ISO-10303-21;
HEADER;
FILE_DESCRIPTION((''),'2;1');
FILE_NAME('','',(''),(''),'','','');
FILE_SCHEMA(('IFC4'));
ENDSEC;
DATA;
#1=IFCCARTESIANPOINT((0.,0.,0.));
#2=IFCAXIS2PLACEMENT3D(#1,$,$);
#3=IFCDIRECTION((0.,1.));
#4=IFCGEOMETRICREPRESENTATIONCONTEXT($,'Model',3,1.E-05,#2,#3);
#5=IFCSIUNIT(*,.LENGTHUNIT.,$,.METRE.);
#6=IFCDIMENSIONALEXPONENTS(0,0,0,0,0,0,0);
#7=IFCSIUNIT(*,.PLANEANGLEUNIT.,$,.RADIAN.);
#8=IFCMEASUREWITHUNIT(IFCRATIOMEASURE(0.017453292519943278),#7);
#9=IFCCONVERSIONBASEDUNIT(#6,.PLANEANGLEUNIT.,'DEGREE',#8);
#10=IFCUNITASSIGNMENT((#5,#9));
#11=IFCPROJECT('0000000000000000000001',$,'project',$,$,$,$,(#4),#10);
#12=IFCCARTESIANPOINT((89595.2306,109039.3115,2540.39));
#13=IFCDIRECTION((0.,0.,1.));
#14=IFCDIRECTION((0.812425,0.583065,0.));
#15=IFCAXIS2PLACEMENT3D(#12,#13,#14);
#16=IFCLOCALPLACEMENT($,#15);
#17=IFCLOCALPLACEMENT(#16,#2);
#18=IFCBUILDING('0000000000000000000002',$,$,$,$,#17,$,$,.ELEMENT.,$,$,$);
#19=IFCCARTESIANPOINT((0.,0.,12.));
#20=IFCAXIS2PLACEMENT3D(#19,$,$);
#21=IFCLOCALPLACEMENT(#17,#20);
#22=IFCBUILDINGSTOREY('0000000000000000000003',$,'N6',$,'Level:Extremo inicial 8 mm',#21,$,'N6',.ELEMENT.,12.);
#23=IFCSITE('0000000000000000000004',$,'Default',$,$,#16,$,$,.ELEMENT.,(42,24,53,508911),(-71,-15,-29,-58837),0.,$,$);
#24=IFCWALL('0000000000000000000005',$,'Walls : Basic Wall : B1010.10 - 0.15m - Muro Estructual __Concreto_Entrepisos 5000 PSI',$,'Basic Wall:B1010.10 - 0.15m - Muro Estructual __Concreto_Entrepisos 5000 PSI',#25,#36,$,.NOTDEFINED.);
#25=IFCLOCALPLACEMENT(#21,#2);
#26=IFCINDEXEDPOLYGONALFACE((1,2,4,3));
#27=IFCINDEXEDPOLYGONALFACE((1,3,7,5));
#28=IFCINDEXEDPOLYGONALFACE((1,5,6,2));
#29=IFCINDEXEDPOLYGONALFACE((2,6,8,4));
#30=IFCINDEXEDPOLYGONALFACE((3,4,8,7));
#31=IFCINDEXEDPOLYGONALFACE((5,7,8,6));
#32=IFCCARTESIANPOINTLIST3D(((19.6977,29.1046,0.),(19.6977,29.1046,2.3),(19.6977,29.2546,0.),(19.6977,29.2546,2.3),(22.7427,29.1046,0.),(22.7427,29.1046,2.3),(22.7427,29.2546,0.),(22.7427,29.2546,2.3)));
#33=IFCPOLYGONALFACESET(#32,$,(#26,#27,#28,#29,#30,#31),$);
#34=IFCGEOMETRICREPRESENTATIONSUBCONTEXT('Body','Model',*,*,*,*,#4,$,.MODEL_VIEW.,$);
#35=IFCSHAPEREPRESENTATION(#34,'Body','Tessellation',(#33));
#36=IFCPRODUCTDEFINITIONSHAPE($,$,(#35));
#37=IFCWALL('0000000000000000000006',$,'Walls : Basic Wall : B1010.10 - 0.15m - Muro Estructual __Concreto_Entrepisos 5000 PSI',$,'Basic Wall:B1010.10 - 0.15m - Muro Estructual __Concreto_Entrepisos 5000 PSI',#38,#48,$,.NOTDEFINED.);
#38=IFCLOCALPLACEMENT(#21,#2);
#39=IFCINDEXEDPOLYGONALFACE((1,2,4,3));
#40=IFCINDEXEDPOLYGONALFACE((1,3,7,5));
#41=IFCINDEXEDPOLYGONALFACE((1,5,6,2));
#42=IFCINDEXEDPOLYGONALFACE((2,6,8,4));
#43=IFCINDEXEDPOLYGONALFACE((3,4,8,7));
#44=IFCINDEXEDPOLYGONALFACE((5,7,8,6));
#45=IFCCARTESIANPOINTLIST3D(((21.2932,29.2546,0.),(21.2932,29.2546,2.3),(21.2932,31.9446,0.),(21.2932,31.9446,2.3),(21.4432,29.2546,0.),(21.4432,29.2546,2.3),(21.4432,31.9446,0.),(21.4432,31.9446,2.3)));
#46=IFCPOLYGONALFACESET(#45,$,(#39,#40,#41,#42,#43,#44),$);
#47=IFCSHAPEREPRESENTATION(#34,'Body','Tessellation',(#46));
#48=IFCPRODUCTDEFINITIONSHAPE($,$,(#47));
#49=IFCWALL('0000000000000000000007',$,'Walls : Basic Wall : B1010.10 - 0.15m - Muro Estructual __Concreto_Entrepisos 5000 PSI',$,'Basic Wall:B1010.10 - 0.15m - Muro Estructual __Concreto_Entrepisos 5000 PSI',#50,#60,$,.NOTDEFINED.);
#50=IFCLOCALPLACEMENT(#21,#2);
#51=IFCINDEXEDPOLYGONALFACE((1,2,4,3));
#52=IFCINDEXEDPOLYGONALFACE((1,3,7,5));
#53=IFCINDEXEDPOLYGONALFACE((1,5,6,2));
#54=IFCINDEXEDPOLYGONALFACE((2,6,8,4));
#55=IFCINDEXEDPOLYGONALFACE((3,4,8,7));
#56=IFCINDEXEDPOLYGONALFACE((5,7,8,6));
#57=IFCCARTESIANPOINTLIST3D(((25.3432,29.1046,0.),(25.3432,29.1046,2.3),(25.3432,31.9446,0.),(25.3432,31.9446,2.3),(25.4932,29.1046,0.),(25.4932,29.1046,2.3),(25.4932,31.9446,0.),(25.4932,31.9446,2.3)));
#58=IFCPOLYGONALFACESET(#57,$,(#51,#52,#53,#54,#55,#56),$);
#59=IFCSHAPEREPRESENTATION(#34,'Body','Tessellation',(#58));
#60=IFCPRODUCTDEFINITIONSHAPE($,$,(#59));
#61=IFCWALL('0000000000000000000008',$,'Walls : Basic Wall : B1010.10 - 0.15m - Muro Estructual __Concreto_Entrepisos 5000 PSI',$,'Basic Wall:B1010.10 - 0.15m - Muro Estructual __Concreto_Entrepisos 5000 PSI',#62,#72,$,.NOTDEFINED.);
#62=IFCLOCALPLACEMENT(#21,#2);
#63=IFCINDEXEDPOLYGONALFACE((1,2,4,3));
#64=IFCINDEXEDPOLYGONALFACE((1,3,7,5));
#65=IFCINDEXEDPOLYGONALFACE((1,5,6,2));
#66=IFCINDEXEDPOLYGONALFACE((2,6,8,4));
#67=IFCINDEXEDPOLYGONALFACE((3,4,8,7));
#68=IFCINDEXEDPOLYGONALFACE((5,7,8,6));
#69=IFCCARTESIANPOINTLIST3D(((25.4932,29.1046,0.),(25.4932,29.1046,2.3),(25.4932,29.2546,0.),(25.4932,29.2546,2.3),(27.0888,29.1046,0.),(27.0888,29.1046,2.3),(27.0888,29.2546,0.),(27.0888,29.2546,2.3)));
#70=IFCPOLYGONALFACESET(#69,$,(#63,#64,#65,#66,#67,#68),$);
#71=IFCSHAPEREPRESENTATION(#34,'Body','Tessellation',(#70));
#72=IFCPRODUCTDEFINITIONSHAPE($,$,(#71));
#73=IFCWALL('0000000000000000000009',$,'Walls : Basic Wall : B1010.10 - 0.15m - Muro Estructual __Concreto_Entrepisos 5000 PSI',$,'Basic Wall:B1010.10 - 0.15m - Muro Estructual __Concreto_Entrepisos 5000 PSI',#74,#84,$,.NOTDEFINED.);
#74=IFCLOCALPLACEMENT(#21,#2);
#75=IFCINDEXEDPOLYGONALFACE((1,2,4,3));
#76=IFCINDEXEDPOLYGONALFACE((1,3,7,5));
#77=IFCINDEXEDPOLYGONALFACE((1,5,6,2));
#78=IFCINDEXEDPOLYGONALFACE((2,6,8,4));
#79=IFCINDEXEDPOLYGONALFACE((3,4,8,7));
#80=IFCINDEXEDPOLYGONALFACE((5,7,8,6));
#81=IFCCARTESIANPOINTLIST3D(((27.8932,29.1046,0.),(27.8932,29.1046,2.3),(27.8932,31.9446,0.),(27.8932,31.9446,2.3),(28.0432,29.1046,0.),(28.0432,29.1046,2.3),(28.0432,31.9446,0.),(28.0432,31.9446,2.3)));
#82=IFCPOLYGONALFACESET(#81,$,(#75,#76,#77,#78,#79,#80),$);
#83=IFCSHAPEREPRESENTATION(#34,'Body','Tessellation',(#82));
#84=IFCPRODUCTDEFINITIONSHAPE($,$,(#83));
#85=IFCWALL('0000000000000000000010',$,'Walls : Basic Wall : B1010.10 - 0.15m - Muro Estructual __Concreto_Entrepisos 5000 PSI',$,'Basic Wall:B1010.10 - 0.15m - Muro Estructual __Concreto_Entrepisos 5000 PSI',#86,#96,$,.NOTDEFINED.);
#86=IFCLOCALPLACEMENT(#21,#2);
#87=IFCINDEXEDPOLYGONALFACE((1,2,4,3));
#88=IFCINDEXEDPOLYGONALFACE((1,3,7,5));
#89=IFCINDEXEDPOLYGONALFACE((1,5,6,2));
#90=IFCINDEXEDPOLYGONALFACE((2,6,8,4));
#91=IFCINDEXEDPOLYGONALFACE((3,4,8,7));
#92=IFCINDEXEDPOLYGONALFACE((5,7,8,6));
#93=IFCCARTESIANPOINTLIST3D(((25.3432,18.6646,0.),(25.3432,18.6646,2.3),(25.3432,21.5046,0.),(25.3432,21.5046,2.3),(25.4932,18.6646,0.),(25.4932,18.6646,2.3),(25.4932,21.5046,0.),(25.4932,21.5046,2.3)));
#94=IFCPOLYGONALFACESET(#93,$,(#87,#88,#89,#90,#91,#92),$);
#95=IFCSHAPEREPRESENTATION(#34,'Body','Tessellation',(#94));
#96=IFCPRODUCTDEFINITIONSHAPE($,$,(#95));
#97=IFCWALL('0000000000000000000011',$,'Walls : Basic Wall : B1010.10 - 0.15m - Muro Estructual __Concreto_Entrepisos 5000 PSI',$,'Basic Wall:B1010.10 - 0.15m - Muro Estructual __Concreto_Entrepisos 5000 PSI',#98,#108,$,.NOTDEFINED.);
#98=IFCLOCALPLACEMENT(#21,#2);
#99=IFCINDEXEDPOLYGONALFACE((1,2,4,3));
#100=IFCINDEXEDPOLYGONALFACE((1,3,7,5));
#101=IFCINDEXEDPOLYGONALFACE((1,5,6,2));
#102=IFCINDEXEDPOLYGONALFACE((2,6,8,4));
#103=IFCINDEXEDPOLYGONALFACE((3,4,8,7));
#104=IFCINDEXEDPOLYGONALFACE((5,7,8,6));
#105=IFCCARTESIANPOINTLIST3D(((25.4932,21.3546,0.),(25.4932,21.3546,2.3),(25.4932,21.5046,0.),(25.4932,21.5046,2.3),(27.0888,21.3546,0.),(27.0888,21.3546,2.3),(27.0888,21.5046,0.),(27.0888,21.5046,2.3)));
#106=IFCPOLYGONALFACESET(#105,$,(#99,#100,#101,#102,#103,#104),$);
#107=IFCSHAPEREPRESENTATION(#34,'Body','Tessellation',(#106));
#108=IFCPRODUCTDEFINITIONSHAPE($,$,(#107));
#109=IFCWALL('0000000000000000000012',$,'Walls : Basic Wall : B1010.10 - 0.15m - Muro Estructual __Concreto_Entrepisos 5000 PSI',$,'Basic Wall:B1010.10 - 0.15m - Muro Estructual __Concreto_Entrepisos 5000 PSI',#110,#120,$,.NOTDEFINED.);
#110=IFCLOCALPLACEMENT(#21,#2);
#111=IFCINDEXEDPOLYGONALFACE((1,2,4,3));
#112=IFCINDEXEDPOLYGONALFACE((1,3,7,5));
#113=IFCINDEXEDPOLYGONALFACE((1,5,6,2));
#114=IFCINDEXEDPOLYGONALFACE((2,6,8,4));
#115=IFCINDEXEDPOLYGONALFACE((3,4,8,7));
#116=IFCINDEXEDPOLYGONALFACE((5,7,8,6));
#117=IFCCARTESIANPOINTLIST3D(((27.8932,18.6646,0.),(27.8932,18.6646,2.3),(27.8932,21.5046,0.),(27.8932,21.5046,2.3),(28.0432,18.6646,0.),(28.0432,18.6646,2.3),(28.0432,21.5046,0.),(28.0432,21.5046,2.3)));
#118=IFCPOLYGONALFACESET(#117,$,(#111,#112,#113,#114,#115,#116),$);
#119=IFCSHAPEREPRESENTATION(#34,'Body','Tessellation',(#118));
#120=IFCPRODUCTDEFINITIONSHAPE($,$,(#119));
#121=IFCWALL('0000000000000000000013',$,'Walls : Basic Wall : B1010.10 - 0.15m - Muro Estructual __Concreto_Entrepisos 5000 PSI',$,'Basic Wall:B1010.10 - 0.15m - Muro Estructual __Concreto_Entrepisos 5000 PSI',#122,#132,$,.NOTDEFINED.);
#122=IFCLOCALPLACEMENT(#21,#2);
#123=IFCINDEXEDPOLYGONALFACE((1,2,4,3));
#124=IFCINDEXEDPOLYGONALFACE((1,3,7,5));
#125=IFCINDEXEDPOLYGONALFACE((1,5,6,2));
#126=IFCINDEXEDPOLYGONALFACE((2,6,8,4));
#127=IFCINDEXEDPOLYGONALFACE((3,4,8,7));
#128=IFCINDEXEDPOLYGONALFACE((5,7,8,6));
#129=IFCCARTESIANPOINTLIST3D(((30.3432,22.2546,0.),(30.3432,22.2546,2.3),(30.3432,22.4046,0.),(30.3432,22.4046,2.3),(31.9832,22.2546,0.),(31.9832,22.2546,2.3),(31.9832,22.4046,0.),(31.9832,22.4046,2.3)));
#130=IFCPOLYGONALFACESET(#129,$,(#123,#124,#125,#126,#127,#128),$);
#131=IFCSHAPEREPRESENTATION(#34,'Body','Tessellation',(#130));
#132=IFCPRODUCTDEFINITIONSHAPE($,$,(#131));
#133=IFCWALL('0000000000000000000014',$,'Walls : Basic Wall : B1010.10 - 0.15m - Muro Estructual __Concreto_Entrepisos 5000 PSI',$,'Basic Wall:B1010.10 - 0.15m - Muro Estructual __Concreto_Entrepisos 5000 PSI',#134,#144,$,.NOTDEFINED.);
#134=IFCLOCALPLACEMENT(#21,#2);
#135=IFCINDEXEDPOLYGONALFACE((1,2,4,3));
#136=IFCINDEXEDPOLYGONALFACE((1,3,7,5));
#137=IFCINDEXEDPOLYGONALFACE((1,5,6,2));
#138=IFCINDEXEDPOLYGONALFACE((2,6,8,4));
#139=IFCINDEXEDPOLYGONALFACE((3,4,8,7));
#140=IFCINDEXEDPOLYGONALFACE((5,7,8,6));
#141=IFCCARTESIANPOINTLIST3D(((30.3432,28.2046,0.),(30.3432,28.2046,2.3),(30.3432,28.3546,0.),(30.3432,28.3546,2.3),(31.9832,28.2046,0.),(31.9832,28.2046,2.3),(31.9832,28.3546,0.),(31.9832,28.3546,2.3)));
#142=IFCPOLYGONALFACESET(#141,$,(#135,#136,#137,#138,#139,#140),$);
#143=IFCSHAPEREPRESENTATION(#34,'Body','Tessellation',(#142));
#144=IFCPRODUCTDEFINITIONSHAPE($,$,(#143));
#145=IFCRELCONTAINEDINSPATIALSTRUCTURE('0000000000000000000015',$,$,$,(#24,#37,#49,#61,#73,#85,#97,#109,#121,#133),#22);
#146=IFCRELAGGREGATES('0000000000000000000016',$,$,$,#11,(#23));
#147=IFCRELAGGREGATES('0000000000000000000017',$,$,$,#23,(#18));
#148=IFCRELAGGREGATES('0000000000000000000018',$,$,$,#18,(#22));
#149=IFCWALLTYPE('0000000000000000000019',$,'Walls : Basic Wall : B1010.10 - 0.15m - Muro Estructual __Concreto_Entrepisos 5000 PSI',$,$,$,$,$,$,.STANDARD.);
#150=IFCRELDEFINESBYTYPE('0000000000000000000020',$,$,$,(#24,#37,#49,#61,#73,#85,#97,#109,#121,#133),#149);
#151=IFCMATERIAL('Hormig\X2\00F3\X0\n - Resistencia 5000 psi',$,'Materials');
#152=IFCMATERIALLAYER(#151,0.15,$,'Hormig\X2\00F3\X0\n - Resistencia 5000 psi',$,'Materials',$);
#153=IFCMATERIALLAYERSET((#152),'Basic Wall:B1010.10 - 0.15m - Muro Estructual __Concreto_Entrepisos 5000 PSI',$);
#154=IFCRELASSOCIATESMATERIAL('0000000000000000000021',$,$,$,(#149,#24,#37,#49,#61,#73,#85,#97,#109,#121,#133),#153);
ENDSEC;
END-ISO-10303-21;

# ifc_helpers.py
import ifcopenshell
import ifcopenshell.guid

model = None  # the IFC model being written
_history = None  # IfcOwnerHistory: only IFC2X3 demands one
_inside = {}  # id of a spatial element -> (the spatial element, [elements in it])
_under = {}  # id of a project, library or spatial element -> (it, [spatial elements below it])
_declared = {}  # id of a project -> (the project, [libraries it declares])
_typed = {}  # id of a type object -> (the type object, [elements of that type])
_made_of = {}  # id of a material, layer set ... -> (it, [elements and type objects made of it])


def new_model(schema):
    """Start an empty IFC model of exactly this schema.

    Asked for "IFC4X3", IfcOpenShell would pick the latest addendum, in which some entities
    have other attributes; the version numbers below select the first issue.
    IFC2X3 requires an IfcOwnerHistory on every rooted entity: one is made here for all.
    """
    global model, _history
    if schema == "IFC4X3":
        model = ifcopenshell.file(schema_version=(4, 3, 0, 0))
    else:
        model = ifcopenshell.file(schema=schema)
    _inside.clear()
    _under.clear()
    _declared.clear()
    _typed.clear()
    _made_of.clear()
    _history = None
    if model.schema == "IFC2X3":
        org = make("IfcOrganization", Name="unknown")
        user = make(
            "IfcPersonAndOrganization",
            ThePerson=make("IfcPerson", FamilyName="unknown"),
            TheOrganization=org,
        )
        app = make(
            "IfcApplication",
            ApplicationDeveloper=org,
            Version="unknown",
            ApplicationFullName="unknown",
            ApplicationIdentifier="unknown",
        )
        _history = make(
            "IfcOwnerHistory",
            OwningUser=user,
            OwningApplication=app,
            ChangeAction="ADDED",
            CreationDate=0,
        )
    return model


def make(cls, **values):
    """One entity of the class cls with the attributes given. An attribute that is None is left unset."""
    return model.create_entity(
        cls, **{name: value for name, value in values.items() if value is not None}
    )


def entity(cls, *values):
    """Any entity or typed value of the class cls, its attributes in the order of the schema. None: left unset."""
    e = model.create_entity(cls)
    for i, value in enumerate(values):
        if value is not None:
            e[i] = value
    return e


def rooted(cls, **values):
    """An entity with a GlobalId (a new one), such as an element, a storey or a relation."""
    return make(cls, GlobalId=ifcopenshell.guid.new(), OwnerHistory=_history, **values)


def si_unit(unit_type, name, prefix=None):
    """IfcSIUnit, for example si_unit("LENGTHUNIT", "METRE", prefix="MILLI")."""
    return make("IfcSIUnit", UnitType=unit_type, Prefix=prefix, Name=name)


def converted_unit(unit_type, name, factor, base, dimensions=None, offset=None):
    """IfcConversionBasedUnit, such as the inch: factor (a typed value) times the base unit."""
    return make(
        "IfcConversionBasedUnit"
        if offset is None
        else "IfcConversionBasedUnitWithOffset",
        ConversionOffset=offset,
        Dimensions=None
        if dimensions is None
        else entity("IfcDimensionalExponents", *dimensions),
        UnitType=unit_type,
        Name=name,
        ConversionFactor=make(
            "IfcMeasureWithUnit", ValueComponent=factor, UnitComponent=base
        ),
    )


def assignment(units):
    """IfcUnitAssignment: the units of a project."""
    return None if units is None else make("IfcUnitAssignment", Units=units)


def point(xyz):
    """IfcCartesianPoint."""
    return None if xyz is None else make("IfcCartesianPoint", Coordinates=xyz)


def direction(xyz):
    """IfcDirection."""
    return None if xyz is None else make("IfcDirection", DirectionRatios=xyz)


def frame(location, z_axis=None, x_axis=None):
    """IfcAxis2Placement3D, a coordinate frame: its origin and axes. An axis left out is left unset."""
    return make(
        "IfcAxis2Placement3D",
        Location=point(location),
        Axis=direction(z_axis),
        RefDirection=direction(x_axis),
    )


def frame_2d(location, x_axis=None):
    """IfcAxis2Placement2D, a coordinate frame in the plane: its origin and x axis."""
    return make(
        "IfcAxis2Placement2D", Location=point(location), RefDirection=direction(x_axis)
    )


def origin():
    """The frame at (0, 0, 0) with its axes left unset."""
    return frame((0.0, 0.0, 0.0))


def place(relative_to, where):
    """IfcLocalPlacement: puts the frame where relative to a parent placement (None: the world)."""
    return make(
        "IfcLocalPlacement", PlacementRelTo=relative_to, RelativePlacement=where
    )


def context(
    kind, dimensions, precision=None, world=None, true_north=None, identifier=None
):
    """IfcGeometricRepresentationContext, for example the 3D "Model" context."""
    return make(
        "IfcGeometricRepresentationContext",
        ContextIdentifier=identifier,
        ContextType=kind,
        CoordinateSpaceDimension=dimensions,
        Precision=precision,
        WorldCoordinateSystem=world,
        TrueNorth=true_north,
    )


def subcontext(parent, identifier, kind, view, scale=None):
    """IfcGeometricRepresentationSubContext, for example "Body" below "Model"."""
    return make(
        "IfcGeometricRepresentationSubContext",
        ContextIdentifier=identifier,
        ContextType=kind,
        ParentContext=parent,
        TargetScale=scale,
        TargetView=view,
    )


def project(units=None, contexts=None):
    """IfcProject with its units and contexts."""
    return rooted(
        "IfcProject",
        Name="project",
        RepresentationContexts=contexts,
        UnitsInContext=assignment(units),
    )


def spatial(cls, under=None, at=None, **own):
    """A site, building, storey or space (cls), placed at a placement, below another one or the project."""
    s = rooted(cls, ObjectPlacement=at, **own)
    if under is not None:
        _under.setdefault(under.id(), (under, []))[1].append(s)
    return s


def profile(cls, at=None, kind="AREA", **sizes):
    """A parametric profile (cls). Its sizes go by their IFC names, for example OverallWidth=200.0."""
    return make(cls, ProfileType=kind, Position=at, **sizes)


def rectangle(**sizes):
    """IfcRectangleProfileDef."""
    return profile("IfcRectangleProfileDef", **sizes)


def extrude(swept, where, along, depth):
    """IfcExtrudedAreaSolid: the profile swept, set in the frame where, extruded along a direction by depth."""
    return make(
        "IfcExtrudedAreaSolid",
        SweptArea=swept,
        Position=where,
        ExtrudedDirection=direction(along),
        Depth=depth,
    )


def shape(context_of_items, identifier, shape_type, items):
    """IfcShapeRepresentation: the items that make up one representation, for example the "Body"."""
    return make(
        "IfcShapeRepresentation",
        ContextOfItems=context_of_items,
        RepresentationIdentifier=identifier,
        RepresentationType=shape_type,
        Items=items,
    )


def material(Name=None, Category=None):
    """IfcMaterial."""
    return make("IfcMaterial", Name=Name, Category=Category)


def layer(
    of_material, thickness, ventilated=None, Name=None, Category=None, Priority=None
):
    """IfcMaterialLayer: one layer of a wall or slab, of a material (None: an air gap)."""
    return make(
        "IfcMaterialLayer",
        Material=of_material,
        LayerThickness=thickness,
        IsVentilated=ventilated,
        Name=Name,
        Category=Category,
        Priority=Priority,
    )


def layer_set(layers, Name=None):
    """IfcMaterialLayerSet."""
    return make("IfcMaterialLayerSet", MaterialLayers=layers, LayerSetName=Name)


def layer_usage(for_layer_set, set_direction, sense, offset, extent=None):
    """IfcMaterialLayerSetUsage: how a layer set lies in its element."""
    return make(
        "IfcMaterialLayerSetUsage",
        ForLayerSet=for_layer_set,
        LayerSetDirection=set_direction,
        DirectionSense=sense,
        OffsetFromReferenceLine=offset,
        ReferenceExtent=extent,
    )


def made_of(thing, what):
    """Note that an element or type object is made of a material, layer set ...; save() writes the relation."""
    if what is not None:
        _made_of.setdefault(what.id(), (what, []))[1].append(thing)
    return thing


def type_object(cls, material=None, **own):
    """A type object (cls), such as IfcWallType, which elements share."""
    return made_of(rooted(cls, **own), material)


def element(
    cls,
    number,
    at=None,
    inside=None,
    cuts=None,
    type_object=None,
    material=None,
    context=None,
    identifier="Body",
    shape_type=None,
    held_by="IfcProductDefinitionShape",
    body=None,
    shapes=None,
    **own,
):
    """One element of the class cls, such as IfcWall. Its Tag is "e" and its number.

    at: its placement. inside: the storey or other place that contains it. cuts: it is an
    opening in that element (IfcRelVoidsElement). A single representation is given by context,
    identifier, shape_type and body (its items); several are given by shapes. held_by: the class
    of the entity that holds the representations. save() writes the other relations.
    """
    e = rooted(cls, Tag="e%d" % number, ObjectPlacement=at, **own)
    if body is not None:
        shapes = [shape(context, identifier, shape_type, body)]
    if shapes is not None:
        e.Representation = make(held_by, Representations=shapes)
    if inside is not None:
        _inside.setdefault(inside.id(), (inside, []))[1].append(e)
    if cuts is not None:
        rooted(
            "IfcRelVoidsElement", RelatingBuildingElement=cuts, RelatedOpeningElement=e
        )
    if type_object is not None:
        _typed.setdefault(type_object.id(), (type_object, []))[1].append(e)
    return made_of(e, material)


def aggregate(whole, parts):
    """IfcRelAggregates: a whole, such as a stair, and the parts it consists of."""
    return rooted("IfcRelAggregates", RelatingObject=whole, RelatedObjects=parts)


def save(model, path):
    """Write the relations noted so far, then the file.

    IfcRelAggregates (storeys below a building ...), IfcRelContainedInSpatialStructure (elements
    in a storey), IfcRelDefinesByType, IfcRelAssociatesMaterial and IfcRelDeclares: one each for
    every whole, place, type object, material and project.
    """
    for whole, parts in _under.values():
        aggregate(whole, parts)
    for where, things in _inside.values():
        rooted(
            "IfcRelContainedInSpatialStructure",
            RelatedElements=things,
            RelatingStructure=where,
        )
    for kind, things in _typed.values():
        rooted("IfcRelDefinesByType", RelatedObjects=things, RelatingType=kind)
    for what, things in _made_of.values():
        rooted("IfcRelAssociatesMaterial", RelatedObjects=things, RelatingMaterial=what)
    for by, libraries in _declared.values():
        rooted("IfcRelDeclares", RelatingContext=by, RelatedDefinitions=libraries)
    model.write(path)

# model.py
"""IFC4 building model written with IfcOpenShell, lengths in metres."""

from ifc_helpers import new_model, entity, si_unit, converted_unit, direction, frame, frame_2d, origin, place, context, subcontext, project, spatial, rectangle, extrude, material, layer, layer_set, layer_usage, type_object, element, save


model = new_model("IFC4")

# Units and contexts
model_context = context("Model", 3, precision=1e-05, world=origin(), true_north=direction((0.0, 1.0)))
body_context = subcontext(model_context, "Body", "Model", "MODEL_VIEW")
ifc_project = project(units=[si_unit("LENGTHUNIT", "METRE"), converted_unit("PLANEANGLEUNIT", "DEGREE", entity("IfcRatioMeasure", 0.017453292519943278), si_unit("PLANEANGLEUNIT", "RADIAN"), dimensions=[0, 0, 0, 0, 0, 0, 0])], contexts=[model_context])

# Site, building, storey
site_placement = place(None, frame((89595.2306, 109039.3115, 2540.39), z_axis=(0.0, 0.0, 1.0), x_axis=(0.812425, 0.583065, 0.0)))
site = spatial("IfcSite", under=ifc_project, at=site_placement, Name="Default", CompositionType="ELEMENT", RefLatitude=(42, 24, 53, 508911), RefLongitude=(-71, -15, -29, -58837), RefElevation=0.0)
building_placement = place(site_placement, origin())
building = spatial("IfcBuilding", under=site, at=building_placement, CompositionType="ELEMENT")
storey_placement = place(building_placement, frame((0.0, 0.0, 12.0)))
storey = spatial("IfcBuildingStorey", under=building, at=storey_placement, Name="N6", ObjectType="Level:Extremo inicial 8 mm", LongName="N6", CompositionType="ELEMENT", Elevation=12.0)

# Walls
ifc_material_1 = material(Name="Hormigón - Resistencia 5000 psi", Category="Materials")
ifc_layer_1 = layer(ifc_material_1, 0.15, Name="Hormigón - Resistencia 5000 psi", Category="Materials")
ifc_layer_set_1 = layer_set([ifc_layer_1], Name="Basic Wall:B1010.10 - 0.15m - Muro Estructual __Concreto_Entrepisos 5000 PSI")
wall_type_1 = type_object("IfcWallType", Name="Walls : Basic Wall : B1010.10 - 0.15m - Muro Estructual __Concreto_Entrepisos 5000 PSI", PredefinedType="STANDARD", material=ifc_layer_set_1)
ifc_layer_usage_1 = layer_usage(ifc_layer_set_1, "AXIS2", "NEGATIVE", 0.075)
wall_1_placement = place(storey_placement, frame((19.6977, 29.1796, 0.0)))
element("IfcWall", 1, at=wall_1_placement, inside=storey, type_object=wall_type_1, material=ifc_layer_usage_1, Name="Walls : Basic Wall : B1010.10 - 0.15m - Muro Estructual __Concreto_Entrepisos 5000 PSI", ObjectType="Basic Wall:B1010.10 - 0.15m - Muro Estructual __Concreto_Entrepisos 5000 PSI", PredefinedType="NOTDEFINED", context=body_context, shape_type="SweptSolid", body=[
    extrude(rectangle(XDim=3.045, YDim=0.15, at=frame_2d((1.5225, 0.0), x_axis=(-1.0, 0.0))), origin(), (0.0, 0.0, 1.0), 2.3),
])
ifc_layer_usage_2 = layer_usage(ifc_layer_set_1, "AXIS2", "NEGATIVE", 0.075)
wall_2_placement = place(storey_placement, frame((21.3682, 31.9446, 0.0), z_axis=(0.0, 0.0, 1.0), x_axis=(0.0, -1.0, 0.0)))
element("IfcWall", 2, at=wall_2_placement, inside=storey, type_object=wall_type_1, material=ifc_layer_usage_2, Name="Walls : Basic Wall : B1010.10 - 0.15m - Muro Estructual __Concreto_Entrepisos 5000 PSI", ObjectType="Basic Wall:B1010.10 - 0.15m - Muro Estructual __Concreto_Entrepisos 5000 PSI", PredefinedType="NOTDEFINED", context=body_context, shape_type="SweptSolid", body=[
    extrude(rectangle(XDim=2.69, YDim=0.15, at=frame_2d((1.345, 0.0), x_axis=(-1.0, 0.0))), origin(), (0.0, 0.0, 1.0), 2.3),
])
ifc_layer_usage_3 = layer_usage(ifc_layer_set_1, "AXIS2", "NEGATIVE", 0.075)
wall_3_placement = place(storey_placement, frame((25.4182, 31.9446, 0.0), z_axis=(0.0, 0.0, 1.0), x_axis=(0.0, -1.0, 0.0)))
element("IfcWall", 3, at=wall_3_placement, inside=storey, type_object=wall_type_1, material=ifc_layer_usage_3, Name="Walls : Basic Wall : B1010.10 - 0.15m - Muro Estructual __Concreto_Entrepisos 5000 PSI", ObjectType="Basic Wall:B1010.10 - 0.15m - Muro Estructual __Concreto_Entrepisos 5000 PSI", PredefinedType="NOTDEFINED", context=body_context, shape_type="SweptSolid", body=[
    extrude(rectangle(XDim=2.84, YDim=0.15, at=frame_2d((1.42, 0.0), x_axis=(-1.0, 0.0))), origin(), (0.0, 0.0, 1.0), 2.3),
])
ifc_layer_usage_4 = layer_usage(ifc_layer_set_1, "AXIS2", "NEGATIVE", 0.075)
wall_4_placement = place(storey_placement, frame((27.0888, 29.1796, 0.0), z_axis=(0.0, 0.0, 1.0), x_axis=(-1.0, 0.0, 0.0)))
element("IfcWall", 4, at=wall_4_placement, inside=storey, type_object=wall_type_1, material=ifc_layer_usage_4, Name="Walls : Basic Wall : B1010.10 - 0.15m - Muro Estructual __Concreto_Entrepisos 5000 PSI", ObjectType="Basic Wall:B1010.10 - 0.15m - Muro Estructual __Concreto_Entrepisos 5000 PSI", PredefinedType="NOTDEFINED", context=body_context, shape_type="SweptSolid", body=[
    extrude(rectangle(XDim=1.5955, YDim=0.15, at=frame_2d((0.7978, 0.0), x_axis=(-1.0, 0.0))), origin(), (0.0, 0.0, 1.0), 2.3),
])
ifc_layer_usage_5 = layer_usage(ifc_layer_set_1, "AXIS2", "NEGATIVE", 0.075)
wall_5_placement = place(storey_placement, frame((27.9682, 31.9446, 0.0), z_axis=(0.0, 0.0, 1.0), x_axis=(0.0, -1.0, 0.0)))
element("IfcWall", 5, at=wall_5_placement, inside=storey, type_object=wall_type_1, material=ifc_layer_usage_5, Name="Walls : Basic Wall : B1010.10 - 0.15m - Muro Estructual __Concreto_Entrepisos 5000 PSI", ObjectType="Basic Wall:B1010.10 - 0.15m - Muro Estructual __Concreto_Entrepisos 5000 PSI", PredefinedType="NOTDEFINED", context=body_context, shape_type="SweptSolid", body=[
    extrude(rectangle(XDim=2.84, YDim=0.15, at=frame_2d((1.42, 0.0), x_axis=(-1.0, 0.0))), origin(), (0.0, 0.0, 1.0), 2.3),
])
ifc_layer_usage_6 = layer_usage(ifc_layer_set_1, "AXIS2", "NEGATIVE", 0.075)
wall_6_placement = place(storey_placement, frame((25.4182, 18.6646, 0.0), z_axis=(0.0, 0.0, 1.0), x_axis=(0.0, 1.0, 0.0)))
element("IfcWall", 6, at=wall_6_placement, inside=storey, type_object=wall_type_1, material=ifc_layer_usage_6, Name="Walls : Basic Wall : B1010.10 - 0.15m - Muro Estructual __Concreto_Entrepisos 5000 PSI", ObjectType="Basic Wall:B1010.10 - 0.15m - Muro Estructual __Concreto_Entrepisos 5000 PSI", PredefinedType="NOTDEFINED", context=body_context, shape_type="SweptSolid", body=[
    extrude(rectangle(XDim=2.84, YDim=0.15, at=frame_2d((1.42, 0.0), x_axis=(-1.0, 0.0))), origin(), (0.0, 0.0, 1.0), 2.3),
])
ifc_layer_usage_7 = layer_usage(ifc_layer_set_1, "AXIS2", "NEGATIVE", 0.075)
wall_7_placement = place(storey_placement, frame((27.0888, 21.4296, 0.0), z_axis=(0.0, 0.0, 1.0), x_axis=(-1.0, 0.0, 0.0)))
element("IfcWall", 7, at=wall_7_placement, inside=storey, type_object=wall_type_1, material=ifc_layer_usage_7, Name="Walls : Basic Wall : B1010.10 - 0.15m - Muro Estructual __Concreto_Entrepisos 5000 PSI", ObjectType="Basic Wall:B1010.10 - 0.15m - Muro Estructual __Concreto_Entrepisos 5000 PSI", PredefinedType="NOTDEFINED", context=body_context, shape_type="SweptSolid", body=[
    extrude(rectangle(XDim=1.5955, YDim=0.15, at=frame_2d((0.7978, 0.0), x_axis=(-1.0, 0.0))), origin(), (0.0, 0.0, 1.0), 2.3),
])
ifc_layer_usage_8 = layer_usage(ifc_layer_set_1, "AXIS2", "NEGATIVE", 0.075)
wall_8_placement = place(storey_placement, frame((27.9682, 18.6646, 0.0), z_axis=(0.0, 0.0, 1.0), x_axis=(0.0, 1.0, 0.0)))
element("IfcWall", 8, at=wall_8_placement, inside=storey, type_object=wall_type_1, material=ifc_layer_usage_8, Name="Walls : Basic Wall : B1010.10 - 0.15m - Muro Estructual __Concreto_Entrepisos 5000 PSI", ObjectType="Basic Wall:B1010.10 - 0.15m - Muro Estructual __Concreto_Entrepisos 5000 PSI", PredefinedType="NOTDEFINED", context=body_context, shape_type="SweptSolid", body=[
    extrude(rectangle(XDim=2.84, YDim=0.15, at=frame_2d((1.42, 0.0), x_axis=(-1.0, 0.0))), origin(), (0.0, 0.0, 1.0), 2.3),
])
ifc_layer_usage_9 = layer_usage(ifc_layer_set_1, "AXIS2", "NEGATIVE", 0.075)
wall_9_placement = place(storey_placement, frame((31.9832, 22.3296, 0.0), z_axis=(0.0, 0.0, 1.0), x_axis=(-1.0, 0.0, 0.0)))
element("IfcWall", 9, at=wall_9_placement, inside=storey, type_object=wall_type_1, material=ifc_layer_usage_9, Name="Walls : Basic Wall : B1010.10 - 0.15m - Muro Estructual __Concreto_Entrepisos 5000 PSI", ObjectType="Basic Wall:B1010.10 - 0.15m - Muro Estructual __Concreto_Entrepisos 5000 PSI", PredefinedType="NOTDEFINED", context=body_context, shape_type="SweptSolid", body=[
    extrude(rectangle(XDim=1.64, YDim=0.15, at=frame_2d((0.82, 0.0), x_axis=(-1.0, 0.0))), origin(), (0.0, 0.0, 1.0), 2.3),
])
ifc_layer_usage_10 = layer_usage(ifc_layer_set_1, "AXIS2", "POSITIVE", -0.075)
wall_10_placement = place(storey_placement, frame((31.9832, 28.2796, 0.0), z_axis=(0.0, 0.0, 1.0), x_axis=(-1.0, 0.0, 0.0)))
element("IfcWall", 10, at=wall_10_placement, inside=storey, type_object=wall_type_1, material=ifc_layer_usage_10, Name="Walls : Basic Wall : B1010.10 - 0.15m - Muro Estructual __Concreto_Entrepisos 5000 PSI", ObjectType="Basic Wall:B1010.10 - 0.15m - Muro Estructual __Concreto_Entrepisos 5000 PSI", PredefinedType="NOTDEFINED", context=body_context, shape_type="SweptSolid", body=[
    extrude(rectangle(XDim=1.64, YDim=0.15, at=frame_2d((0.82, 0.0), x_axis=(-1.0, 0.0))), origin(), (0.0, 0.0, 1.0), 2.3),
])

save(model, "model.ifc")
